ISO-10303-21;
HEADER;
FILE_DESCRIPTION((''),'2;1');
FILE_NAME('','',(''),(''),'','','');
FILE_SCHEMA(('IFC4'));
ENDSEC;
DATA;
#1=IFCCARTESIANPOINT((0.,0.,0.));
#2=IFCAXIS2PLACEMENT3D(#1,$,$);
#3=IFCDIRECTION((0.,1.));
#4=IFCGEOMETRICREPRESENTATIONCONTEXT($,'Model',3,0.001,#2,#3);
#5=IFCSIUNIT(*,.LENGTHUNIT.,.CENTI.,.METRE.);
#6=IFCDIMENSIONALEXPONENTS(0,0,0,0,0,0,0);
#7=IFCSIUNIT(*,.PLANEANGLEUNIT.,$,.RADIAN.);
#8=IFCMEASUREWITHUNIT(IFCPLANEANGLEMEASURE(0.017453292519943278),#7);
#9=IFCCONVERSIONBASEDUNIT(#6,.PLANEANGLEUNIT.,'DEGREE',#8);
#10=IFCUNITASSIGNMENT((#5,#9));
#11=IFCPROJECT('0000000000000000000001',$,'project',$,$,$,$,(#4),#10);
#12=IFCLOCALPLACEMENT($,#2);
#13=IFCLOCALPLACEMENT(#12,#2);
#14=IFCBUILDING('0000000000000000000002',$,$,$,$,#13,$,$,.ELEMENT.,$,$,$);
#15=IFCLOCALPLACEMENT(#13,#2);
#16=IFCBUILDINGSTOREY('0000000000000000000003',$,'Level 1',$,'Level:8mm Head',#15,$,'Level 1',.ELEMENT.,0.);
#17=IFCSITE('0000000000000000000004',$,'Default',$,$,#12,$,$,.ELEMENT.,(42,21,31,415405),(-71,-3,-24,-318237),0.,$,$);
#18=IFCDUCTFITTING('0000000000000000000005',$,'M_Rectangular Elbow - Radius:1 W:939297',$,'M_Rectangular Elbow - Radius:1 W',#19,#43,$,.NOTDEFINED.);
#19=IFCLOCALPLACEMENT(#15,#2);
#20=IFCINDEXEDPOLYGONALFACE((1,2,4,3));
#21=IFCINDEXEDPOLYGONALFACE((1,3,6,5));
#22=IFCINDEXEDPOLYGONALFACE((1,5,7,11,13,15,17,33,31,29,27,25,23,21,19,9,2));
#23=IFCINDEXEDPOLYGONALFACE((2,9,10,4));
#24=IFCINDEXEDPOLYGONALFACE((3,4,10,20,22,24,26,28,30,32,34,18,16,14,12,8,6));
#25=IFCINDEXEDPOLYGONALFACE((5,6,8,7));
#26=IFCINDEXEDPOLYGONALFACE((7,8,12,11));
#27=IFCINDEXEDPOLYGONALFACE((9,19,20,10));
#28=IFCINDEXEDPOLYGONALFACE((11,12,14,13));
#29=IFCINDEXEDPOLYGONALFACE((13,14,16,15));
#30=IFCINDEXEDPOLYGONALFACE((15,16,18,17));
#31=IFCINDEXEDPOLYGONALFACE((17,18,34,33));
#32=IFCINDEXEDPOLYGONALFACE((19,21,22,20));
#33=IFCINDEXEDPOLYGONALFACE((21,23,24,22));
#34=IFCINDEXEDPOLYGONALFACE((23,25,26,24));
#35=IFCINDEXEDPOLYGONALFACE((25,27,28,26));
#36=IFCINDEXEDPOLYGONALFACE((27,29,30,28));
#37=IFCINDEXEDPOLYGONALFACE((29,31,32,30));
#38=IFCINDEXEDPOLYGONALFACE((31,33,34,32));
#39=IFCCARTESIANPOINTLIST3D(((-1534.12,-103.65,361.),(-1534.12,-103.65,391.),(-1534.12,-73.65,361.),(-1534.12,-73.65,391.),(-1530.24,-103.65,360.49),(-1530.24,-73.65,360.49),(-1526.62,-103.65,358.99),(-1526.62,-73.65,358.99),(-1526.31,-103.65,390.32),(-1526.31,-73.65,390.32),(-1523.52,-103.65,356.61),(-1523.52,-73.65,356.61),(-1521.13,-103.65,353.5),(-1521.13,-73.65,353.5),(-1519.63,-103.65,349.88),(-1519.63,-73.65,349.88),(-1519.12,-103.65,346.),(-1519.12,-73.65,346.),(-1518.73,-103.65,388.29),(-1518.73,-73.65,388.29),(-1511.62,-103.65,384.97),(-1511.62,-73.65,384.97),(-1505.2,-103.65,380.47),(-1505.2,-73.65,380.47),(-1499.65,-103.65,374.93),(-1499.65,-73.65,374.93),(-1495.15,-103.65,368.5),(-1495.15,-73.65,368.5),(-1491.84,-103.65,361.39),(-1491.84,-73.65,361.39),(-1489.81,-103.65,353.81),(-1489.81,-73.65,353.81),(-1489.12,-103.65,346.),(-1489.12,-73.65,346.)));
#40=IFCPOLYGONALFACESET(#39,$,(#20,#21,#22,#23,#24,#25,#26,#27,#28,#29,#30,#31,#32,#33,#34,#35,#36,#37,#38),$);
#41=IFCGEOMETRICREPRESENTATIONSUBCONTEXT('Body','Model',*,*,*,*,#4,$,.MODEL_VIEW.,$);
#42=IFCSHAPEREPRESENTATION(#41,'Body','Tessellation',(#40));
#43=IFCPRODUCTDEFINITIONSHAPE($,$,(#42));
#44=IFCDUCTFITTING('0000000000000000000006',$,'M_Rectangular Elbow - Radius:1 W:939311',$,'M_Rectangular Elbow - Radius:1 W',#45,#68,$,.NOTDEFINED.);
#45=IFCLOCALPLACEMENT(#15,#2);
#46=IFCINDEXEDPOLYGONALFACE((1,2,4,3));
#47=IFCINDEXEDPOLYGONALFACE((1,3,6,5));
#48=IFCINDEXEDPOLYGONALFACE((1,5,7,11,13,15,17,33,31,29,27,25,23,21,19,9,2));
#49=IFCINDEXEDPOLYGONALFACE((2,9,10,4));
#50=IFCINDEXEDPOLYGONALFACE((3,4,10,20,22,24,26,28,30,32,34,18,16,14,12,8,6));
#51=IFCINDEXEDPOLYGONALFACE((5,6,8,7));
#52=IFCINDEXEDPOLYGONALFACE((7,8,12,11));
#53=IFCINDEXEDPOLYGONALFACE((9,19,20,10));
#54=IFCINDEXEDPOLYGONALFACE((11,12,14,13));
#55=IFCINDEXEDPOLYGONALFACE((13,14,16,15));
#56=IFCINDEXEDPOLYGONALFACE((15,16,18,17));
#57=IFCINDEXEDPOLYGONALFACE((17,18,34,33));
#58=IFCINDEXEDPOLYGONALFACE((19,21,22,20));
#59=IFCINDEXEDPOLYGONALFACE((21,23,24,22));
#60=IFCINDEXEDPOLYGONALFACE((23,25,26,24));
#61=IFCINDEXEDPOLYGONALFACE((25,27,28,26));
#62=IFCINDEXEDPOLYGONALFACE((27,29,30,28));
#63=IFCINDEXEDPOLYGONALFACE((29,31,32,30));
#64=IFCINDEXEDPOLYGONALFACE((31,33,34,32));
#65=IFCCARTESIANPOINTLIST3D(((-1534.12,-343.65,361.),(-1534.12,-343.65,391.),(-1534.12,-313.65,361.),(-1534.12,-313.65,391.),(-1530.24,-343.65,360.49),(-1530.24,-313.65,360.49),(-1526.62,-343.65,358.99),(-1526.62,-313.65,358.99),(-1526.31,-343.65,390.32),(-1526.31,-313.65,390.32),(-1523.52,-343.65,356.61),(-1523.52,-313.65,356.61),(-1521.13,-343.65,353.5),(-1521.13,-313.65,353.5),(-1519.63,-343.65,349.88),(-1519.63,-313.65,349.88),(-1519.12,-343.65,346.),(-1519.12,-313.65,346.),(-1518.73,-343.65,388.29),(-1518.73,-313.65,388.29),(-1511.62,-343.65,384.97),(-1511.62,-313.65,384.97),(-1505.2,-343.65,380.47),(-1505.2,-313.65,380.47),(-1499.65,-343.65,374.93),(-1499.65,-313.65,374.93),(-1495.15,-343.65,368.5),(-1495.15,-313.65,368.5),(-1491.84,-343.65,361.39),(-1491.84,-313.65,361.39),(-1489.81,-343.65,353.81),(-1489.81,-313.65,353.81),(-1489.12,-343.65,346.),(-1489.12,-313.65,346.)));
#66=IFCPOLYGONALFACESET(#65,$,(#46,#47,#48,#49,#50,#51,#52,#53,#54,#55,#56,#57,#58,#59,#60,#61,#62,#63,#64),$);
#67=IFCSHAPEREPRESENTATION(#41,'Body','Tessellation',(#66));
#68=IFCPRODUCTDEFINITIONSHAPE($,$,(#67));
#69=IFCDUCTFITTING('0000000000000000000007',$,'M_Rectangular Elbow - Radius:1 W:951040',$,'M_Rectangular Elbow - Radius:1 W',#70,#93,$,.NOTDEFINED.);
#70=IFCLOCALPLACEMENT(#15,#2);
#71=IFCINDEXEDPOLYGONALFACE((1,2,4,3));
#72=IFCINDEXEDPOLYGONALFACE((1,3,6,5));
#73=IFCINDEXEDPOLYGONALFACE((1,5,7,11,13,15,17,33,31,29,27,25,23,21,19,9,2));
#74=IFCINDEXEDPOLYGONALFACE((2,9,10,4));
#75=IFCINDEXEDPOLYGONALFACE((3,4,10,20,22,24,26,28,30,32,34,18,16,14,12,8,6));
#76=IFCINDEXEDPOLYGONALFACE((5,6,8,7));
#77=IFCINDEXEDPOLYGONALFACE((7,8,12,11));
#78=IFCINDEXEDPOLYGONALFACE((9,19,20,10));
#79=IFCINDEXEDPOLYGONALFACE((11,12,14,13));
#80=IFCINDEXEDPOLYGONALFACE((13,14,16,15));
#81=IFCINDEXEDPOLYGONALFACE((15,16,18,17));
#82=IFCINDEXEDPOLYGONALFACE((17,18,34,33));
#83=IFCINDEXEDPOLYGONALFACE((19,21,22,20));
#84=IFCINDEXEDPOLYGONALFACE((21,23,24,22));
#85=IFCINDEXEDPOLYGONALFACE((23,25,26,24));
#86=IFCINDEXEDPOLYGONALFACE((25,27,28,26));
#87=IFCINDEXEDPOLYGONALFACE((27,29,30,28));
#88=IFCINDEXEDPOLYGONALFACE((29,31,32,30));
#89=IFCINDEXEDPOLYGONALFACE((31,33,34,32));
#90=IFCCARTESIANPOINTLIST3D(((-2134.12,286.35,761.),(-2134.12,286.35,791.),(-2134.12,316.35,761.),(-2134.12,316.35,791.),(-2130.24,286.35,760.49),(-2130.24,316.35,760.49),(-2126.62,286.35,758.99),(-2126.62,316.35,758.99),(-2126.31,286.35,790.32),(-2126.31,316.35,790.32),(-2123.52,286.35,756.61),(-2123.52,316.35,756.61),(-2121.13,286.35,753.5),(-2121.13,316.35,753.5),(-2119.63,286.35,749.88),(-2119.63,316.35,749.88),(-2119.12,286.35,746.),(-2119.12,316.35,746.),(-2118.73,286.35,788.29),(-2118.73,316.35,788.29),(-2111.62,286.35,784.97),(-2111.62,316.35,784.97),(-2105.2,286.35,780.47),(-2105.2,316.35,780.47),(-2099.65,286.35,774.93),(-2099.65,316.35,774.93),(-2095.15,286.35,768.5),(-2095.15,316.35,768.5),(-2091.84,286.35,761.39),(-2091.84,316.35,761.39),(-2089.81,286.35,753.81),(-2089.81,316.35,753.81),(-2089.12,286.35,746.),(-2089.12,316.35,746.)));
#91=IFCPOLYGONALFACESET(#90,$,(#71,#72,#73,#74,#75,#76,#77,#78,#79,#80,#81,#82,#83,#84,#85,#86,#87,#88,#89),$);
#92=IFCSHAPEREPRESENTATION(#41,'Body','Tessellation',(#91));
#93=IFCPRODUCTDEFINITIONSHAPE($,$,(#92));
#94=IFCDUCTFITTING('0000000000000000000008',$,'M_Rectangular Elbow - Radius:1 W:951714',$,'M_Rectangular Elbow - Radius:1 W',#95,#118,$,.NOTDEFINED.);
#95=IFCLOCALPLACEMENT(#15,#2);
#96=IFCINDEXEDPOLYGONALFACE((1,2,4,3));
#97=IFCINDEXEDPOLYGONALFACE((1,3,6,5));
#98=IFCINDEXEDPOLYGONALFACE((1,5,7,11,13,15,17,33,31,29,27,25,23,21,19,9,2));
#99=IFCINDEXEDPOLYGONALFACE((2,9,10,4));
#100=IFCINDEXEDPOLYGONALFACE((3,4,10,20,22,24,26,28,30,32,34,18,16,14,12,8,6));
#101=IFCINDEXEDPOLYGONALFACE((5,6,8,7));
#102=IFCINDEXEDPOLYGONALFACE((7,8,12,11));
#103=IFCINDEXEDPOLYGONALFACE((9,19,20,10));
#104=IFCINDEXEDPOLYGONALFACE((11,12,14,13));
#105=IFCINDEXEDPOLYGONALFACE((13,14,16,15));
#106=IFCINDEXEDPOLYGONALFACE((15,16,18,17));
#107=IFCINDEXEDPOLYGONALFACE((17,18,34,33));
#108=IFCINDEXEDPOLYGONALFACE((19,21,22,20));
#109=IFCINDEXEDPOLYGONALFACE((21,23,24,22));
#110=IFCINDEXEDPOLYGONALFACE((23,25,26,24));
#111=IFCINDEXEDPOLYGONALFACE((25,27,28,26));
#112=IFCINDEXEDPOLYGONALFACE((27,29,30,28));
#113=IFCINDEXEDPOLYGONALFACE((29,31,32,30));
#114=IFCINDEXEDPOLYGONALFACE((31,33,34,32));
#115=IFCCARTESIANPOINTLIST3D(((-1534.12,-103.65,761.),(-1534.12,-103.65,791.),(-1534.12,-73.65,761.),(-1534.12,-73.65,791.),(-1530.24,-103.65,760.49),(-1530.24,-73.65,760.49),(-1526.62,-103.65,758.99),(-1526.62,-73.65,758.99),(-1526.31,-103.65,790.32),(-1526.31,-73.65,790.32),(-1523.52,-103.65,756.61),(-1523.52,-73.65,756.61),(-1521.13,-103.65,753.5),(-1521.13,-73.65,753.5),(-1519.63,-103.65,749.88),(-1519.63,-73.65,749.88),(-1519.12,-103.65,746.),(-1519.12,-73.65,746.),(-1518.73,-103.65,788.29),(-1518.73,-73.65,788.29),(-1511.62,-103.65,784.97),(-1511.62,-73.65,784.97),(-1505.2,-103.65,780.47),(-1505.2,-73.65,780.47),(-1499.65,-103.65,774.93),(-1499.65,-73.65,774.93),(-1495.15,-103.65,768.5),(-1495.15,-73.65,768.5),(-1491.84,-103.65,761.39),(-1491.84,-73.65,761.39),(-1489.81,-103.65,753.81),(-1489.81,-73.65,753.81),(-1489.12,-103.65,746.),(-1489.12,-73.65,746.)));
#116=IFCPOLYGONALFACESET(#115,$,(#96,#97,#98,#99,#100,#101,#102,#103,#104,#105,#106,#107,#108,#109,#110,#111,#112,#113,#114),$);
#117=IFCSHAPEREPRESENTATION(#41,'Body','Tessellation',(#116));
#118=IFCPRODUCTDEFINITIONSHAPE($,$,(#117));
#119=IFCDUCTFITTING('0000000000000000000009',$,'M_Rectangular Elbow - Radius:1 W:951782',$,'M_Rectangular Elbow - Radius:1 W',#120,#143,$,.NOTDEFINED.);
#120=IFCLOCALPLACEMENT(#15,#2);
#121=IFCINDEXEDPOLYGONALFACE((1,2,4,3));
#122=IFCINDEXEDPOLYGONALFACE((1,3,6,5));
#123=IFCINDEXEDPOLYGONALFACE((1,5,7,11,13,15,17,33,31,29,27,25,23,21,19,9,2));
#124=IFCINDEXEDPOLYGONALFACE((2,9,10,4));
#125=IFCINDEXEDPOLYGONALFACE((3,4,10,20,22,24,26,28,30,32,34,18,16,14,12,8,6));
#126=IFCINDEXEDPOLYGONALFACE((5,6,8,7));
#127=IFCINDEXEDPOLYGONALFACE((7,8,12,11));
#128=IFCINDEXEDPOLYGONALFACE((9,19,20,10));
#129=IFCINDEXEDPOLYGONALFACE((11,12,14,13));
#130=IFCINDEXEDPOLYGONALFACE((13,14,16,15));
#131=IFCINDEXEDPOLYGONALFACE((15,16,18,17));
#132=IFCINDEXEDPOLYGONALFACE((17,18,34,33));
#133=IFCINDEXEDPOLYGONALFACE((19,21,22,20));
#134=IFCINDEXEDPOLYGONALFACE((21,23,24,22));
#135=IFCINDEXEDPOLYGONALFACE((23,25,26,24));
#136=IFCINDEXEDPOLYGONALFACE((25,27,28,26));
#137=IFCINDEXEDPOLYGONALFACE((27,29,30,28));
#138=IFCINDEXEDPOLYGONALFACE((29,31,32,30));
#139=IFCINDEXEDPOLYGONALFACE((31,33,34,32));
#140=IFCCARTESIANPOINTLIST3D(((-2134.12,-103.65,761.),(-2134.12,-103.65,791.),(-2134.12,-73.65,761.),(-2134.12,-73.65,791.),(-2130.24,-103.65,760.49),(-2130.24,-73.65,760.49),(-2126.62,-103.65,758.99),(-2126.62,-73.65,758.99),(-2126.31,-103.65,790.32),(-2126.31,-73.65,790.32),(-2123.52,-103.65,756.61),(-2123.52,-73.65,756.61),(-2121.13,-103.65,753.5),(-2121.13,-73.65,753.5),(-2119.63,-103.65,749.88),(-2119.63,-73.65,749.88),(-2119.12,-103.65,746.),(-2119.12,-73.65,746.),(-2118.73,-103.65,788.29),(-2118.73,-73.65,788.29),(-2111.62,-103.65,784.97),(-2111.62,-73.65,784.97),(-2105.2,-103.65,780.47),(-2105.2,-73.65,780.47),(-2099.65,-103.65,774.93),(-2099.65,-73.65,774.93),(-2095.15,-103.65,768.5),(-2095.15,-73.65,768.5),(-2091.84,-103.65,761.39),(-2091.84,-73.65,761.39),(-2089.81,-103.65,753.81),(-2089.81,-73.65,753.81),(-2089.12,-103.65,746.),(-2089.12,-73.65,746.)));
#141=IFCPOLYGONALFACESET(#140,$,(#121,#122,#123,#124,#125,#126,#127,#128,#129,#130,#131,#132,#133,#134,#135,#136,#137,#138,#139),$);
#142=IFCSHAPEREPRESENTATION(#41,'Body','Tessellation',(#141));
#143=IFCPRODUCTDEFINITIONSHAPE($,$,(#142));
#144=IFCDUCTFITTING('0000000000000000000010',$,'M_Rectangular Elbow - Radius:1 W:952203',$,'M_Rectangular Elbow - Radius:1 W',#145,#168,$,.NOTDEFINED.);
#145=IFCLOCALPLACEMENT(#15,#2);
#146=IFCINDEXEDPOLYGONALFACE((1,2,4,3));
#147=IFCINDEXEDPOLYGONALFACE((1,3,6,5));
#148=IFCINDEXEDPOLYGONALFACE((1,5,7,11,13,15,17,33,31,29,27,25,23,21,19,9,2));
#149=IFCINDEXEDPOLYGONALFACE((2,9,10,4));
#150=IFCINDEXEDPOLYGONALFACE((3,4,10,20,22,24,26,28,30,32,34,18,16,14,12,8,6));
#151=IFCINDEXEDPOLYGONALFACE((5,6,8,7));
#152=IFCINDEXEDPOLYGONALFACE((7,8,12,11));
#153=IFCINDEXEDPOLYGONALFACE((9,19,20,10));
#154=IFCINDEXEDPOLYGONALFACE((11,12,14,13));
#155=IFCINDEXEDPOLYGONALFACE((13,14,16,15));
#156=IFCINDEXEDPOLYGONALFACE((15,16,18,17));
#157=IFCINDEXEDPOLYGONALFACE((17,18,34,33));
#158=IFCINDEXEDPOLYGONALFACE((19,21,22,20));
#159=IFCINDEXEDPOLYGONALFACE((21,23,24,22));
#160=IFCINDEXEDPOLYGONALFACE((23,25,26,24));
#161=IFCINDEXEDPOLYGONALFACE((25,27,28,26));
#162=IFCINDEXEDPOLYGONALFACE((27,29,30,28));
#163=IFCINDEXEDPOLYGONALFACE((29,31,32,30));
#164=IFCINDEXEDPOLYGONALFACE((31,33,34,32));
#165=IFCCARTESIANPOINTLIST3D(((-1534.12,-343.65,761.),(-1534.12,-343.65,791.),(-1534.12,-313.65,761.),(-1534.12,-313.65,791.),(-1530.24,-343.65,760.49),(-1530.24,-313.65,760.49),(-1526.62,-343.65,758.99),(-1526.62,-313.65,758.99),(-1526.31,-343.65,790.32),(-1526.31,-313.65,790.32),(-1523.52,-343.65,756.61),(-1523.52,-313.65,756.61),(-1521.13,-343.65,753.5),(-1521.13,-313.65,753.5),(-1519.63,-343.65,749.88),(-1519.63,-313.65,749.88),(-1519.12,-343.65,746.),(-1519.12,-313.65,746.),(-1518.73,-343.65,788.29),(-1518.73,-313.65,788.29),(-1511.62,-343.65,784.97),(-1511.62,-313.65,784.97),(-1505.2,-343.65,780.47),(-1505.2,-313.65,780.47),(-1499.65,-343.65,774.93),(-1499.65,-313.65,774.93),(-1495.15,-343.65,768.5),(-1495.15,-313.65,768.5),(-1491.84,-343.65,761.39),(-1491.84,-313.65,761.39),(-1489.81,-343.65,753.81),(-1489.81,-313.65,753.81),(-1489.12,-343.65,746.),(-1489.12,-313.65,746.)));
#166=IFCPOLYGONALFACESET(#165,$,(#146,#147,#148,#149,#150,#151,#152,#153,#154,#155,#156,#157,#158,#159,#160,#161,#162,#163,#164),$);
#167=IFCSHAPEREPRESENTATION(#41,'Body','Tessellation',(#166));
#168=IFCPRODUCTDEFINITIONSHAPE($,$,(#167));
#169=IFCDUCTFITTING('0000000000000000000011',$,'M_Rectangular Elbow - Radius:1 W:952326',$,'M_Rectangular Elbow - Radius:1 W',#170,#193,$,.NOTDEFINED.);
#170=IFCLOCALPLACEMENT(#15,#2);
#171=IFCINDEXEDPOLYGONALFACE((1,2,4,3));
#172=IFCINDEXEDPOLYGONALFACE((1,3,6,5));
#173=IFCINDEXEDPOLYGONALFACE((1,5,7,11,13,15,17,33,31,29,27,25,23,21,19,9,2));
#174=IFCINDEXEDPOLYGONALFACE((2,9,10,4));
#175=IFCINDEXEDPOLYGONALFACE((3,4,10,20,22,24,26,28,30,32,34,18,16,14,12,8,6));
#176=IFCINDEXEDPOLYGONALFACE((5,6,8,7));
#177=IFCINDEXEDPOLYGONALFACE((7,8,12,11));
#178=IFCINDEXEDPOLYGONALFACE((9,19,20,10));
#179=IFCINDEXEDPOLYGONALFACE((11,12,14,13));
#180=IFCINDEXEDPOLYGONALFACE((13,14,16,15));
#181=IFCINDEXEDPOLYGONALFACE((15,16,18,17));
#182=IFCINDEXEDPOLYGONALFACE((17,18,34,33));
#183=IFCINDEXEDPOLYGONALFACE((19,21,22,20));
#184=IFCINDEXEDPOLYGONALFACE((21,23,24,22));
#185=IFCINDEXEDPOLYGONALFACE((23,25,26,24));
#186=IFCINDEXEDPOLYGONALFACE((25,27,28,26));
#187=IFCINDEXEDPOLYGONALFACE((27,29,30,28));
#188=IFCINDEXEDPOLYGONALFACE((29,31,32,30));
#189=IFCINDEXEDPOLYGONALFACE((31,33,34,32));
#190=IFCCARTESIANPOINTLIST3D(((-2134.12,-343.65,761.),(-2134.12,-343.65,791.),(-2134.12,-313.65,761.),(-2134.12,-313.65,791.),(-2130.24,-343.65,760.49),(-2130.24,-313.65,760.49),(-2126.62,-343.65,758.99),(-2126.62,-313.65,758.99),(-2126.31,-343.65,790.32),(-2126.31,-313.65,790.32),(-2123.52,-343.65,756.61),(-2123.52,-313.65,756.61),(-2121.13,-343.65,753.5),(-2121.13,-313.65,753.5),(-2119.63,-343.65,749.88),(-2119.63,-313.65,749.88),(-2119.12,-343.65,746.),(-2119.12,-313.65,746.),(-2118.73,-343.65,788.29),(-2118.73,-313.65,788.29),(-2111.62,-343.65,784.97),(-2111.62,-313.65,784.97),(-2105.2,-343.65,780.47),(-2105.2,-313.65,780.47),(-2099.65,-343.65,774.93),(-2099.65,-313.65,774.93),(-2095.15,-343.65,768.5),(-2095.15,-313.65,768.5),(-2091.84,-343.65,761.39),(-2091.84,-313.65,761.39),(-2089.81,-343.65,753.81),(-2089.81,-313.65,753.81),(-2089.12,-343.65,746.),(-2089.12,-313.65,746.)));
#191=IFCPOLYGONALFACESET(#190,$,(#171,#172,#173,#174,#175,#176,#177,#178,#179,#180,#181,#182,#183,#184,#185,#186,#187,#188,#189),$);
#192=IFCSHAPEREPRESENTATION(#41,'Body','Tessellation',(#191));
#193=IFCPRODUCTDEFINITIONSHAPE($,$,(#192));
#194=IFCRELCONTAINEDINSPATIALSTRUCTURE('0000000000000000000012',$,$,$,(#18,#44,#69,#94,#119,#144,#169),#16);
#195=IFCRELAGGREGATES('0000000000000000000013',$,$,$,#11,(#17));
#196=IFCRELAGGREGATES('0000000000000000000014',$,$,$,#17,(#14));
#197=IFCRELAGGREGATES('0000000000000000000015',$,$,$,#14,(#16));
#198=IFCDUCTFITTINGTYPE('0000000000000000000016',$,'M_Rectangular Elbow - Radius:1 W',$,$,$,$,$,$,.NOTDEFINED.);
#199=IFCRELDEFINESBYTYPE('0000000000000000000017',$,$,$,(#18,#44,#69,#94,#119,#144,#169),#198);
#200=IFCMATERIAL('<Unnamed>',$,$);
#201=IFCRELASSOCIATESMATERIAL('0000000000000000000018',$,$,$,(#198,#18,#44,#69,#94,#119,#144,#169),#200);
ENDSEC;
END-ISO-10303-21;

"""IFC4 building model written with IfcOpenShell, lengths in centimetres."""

from ifc_helpers import new_model, entity, si_unit, converted_unit, direction, frame, origin, place, context, subcontext, project, spatial, line, arc, indexed_curve, outline, extrude, source, transform, mapped, material, type_object, type_shapes, element, save


model = new_model("IFC4")

# Units and contexts
model_context = context("Model", 3, precision=0.001, world=origin(), true_north=direction((0.0, 1.0)))
body_context = subcontext(model_context, "Body", "Model", "MODEL_VIEW")
ifc_project = project(units=[si_unit("LENGTHUNIT", "METRE", prefix="CENTI"), converted_unit("PLANEANGLEUNIT", "DEGREE", entity("IfcPlaneAngleMeasure", 0.017453292519943278), si_unit("PLANEANGLEUNIT", "RADIAN"), dimensions=[0, 0, 0, 0, 0, 0, 0])], contexts=[model_context])

# Site, building, storey
site_placement = place(None, origin())
site = spatial("IfcSite", under=ifc_project, at=site_placement, Name="Default", CompositionType="ELEMENT", RefLatitude=(42, 21, 31, 415405), RefLongitude=(-71, -3, -24, -318237), RefElevation=0.0)
building_placement = place(site_placement, origin())
building = spatial("IfcBuilding", under=site, at=building_placement, CompositionType="ELEMENT")
storey_placement = place(building_placement, origin())
storey = spatial("IfcBuildingStorey", under=building, at=storey_placement, Name="Level 1", ObjectType="Level:8mm Head", LongName="Level 1", CompositionType="ELEMENT", Elevation=0.0)

# Duct fittings
ifc_material = material(Name="<Unnamed>")
duct_fitting_type_1 = type_object("IfcDuctFittingType", Name="M_Rectangular Elbow - Radius:1 W", PredefinedType="NOTDEFINED", material=ifc_material)
shared_shape_1 = source(origin(), body_context, "Body", "SweptSolid", [
    extrude(outline(indexed_curve([(-30.0, -15.0), (0.0, -15.0), (4.39, -4.39), (15.0, 0.0), (15.0, 30.0), (-16.82, 16.82)], segments=[line(1, 2), arc(2, 3, 4), line(4, 5), arc(5, 6, 1)], self_intersect=False)), frame((-15.0, 15.0, -15.0), z_axis=(0.0, 0.0, 1.0), x_axis=(-1.0, 0.0, 0.0)), (0.0, 0.0, 1.0), 30.0),
])
type_shapes(duct_fitting_type_1, [shared_shape_1])
for number, where, z_axis, x_axis, name in (
    (1, (-1504.12, -88.65, 376.0), (0.0, -1.0, 0.0), (0.0, 0.0, 1.0), "M_Rectangular Elbow - Radius:1 W:939297"),
    (2, (-1504.12, -328.65, 376.0), (0.0, -1.0, 0.0), (0.0, 0.0, 1.0), "M_Rectangular Elbow - Radius:1 W:939311"),
    (3, (-2104.12, 301.35, 776.0), (0.0, 1.0, 0.0), (1.0, 0.0, 0.0), "M_Rectangular Elbow - Radius:1 W:951040"),
    (4, (-1504.12, -88.65, 776.0), (0.0, 1.0, 0.0), (1.0, 0.0, 0.0), "M_Rectangular Elbow - Radius:1 W:951714"),
    (5, (-2104.12, -88.65, 776.0), (0.0, 1.0, 0.0), (1.0, 0.0, 0.0), "M_Rectangular Elbow - Radius:1 W:951782"),
    (6, (-1504.12, -328.65, 776.0), (0.0, 1.0, 0.0), (1.0, 0.0, 0.0), "M_Rectangular Elbow - Radius:1 W:952203"),
    (7, (-2104.12, -328.65, 776.0), (0.0, 1.0, 0.0), (1.0, 0.0, 0.0), "M_Rectangular Elbow - Radius:1 W:952326"),
):
    element("IfcDuctFitting", number, at=place(storey_placement, frame(where, z_axis=z_axis, x_axis=x_axis)), inside=storey, type_object=duct_fitting_type_1, material=ifc_material, Name=name, ObjectType="M_Rectangular Elbow - Radius:1 W", PredefinedType="NOTDEFINED", context=body_context, shape_type="MappedRepresentation", body=[
        mapped(shared_shape_1, transform((0.0, 0.0, 0.0), scale=1.0)),
    ])

save(model, "model.ifc")
